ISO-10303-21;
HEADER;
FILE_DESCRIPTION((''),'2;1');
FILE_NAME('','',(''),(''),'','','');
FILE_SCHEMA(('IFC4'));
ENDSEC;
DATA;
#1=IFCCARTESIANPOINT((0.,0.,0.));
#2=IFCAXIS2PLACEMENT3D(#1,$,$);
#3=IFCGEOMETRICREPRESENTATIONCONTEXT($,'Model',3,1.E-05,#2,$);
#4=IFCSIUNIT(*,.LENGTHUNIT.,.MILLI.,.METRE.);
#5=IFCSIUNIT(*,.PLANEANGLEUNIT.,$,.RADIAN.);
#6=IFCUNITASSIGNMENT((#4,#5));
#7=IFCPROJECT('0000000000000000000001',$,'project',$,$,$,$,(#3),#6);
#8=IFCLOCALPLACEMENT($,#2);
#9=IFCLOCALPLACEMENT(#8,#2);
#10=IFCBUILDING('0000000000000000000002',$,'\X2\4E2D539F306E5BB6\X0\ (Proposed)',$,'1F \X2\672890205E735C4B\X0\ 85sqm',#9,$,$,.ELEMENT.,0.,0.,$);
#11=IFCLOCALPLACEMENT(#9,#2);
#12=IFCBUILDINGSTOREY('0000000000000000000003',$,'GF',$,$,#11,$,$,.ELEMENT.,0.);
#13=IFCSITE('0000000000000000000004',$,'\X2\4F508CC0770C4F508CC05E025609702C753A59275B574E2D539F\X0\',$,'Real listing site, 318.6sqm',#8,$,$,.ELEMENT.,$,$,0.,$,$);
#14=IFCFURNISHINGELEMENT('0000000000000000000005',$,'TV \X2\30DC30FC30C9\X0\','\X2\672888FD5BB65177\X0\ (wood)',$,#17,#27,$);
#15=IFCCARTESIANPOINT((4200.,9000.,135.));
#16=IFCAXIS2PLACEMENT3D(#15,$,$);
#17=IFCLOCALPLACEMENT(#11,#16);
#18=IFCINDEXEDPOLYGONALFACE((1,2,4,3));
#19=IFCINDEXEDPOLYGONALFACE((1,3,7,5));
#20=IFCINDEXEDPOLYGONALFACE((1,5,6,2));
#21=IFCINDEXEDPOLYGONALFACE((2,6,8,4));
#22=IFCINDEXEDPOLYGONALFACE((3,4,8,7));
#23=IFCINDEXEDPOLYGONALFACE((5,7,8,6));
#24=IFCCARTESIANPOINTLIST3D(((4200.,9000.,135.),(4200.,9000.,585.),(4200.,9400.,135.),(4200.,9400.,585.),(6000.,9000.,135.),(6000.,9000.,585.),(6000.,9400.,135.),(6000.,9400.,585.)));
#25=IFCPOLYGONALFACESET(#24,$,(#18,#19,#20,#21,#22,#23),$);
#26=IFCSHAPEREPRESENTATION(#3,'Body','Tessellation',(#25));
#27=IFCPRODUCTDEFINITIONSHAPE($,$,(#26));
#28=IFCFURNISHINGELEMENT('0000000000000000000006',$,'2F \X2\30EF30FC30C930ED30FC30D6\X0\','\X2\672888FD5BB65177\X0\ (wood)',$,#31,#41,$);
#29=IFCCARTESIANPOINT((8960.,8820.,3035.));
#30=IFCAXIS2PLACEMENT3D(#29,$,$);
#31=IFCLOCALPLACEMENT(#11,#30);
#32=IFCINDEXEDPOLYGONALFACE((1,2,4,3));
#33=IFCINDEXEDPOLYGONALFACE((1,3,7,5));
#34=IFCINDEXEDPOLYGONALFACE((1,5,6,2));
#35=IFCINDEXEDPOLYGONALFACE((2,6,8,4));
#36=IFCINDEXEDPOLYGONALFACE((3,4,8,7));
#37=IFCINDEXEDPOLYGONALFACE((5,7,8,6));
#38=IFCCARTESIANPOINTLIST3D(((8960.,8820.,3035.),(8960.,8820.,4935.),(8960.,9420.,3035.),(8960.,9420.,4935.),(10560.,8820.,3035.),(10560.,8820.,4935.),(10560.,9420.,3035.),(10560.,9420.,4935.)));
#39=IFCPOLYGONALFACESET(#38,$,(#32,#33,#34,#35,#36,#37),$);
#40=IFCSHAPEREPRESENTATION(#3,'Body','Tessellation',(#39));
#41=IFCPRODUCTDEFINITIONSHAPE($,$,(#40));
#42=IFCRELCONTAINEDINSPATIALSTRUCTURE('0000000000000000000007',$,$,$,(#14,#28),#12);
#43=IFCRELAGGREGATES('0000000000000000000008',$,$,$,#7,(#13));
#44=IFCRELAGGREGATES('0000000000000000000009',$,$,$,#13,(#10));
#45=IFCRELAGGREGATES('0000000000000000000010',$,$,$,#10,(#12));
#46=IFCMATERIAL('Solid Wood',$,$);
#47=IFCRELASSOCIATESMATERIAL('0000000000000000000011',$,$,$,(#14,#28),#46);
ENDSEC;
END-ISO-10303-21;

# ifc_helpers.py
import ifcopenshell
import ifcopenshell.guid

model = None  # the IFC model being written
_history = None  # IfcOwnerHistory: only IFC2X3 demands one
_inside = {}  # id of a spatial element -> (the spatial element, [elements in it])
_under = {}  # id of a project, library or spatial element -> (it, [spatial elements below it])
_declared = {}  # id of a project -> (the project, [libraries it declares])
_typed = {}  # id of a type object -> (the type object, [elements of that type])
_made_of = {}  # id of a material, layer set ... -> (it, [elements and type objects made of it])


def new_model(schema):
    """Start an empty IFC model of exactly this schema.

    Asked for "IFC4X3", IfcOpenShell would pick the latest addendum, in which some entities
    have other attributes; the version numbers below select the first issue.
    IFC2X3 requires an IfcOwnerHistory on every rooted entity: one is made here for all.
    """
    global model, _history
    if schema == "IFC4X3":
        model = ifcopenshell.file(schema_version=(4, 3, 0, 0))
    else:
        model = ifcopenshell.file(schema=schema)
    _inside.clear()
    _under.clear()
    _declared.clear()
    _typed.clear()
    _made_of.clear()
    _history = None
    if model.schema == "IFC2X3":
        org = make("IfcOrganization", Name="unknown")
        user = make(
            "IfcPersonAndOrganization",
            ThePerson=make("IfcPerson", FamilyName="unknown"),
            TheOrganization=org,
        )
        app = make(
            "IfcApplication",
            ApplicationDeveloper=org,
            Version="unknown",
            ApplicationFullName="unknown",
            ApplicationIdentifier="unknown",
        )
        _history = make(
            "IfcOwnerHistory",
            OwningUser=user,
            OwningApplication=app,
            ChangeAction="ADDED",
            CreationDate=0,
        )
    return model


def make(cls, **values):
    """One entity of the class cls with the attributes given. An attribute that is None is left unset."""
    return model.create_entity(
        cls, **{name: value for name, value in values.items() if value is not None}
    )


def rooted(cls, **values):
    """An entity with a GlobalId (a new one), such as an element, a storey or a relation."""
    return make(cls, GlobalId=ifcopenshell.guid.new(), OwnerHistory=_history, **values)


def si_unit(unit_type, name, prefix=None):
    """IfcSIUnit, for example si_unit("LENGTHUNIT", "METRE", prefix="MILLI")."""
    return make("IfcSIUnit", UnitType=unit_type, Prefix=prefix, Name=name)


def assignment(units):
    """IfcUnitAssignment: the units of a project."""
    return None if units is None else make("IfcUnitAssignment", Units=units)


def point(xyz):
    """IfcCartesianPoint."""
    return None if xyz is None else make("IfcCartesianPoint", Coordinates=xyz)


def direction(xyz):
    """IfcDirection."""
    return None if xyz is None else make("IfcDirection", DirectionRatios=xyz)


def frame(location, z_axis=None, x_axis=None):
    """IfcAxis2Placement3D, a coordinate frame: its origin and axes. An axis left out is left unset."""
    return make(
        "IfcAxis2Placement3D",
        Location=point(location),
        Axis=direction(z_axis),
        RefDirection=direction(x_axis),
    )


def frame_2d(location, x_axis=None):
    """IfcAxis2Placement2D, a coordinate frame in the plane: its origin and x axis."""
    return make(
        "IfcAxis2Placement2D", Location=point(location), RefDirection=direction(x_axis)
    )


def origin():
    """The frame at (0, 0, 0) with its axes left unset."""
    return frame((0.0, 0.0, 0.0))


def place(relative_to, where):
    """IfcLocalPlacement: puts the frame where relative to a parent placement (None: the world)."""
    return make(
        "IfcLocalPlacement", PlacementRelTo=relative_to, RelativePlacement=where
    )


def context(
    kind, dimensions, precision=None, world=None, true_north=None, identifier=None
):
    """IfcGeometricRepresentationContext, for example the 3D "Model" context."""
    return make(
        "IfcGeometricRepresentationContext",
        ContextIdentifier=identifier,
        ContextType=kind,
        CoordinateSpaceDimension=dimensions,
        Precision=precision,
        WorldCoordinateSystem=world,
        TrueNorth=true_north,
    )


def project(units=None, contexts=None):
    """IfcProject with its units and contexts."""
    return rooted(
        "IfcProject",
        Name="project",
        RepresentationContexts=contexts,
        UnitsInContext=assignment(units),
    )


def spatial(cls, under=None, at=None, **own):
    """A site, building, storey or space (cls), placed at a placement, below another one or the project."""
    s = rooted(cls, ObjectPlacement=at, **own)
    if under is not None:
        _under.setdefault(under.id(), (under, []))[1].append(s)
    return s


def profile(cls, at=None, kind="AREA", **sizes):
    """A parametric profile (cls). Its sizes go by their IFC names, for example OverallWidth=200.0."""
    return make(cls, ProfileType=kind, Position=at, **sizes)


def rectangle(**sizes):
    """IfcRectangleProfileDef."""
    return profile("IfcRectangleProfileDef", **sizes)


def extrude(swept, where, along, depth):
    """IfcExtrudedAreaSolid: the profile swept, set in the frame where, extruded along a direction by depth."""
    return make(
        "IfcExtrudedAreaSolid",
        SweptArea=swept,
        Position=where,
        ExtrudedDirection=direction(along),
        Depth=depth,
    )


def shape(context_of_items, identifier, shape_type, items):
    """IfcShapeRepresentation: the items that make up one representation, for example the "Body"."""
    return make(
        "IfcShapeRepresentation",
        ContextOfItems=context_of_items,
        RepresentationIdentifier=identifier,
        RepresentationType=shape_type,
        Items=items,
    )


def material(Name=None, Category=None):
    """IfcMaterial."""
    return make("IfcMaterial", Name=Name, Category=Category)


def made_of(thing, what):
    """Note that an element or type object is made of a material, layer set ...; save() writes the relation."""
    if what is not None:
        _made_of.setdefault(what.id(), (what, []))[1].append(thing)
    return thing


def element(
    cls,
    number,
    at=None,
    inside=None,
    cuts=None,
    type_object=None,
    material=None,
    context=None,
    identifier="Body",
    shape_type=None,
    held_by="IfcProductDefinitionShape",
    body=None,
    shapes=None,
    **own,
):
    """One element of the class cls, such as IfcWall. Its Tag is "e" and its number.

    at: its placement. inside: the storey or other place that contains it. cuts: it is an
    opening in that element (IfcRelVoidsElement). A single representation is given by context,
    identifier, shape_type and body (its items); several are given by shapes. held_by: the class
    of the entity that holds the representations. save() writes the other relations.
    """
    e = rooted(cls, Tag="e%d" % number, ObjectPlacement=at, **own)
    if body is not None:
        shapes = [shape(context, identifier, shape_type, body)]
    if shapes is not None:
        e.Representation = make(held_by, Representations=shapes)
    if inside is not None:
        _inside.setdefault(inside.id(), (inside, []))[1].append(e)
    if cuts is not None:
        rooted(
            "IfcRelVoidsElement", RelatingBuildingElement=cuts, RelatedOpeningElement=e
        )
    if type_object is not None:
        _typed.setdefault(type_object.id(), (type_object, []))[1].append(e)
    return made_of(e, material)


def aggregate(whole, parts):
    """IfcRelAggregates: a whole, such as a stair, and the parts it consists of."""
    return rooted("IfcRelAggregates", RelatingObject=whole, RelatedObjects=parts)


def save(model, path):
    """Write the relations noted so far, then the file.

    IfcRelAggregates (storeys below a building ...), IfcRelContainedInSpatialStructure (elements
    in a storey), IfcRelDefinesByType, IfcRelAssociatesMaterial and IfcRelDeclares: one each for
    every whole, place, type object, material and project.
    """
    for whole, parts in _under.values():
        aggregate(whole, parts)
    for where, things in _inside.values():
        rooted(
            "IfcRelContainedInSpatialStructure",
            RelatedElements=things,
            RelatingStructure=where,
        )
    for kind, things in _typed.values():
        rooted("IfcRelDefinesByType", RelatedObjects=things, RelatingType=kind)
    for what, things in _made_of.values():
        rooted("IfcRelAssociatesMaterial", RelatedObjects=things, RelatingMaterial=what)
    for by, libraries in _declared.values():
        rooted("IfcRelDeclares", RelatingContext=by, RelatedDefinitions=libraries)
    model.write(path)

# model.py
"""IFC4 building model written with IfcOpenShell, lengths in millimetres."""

from ifc_helpers import new_model, si_unit, frame, frame_2d, origin, place, context, project, spatial, rectangle, extrude, material, element, save


model = new_model("IFC4")

# Units and contexts
model_context = context("Model", 3, precision=1e-05, world=origin())
ifc_project = project(units=[si_unit("LENGTHUNIT", "METRE", prefix="MILLI"), si_unit("PLANEANGLEUNIT", "RADIAN")], contexts=[model_context])

# Site, building, storey
site_placement = place(None, origin())
site = spatial("IfcSite", under=ifc_project, at=site_placement, Name="佐賀県佐賀市嘉瀬町大字中原", ObjectType="Real listing site, 318.6sqm", CompositionType="ELEMENT", RefElevation=0.0)
building_placement = place(site_placement, origin())
building = spatial("IfcBuilding", under=site, at=building_placement, Name="中原の家 (Proposed)", ObjectType="1F 木造平屋 85sqm", CompositionType="ELEMENT", ElevationOfRefHeight=0.0, ElevationOfTerrain=0.0)
storey_placement = place(building_placement, origin())
storey = spatial("IfcBuildingStorey", under=building, at=storey_placement, Name="GF", CompositionType="ELEMENT", Elevation=0.0)

# Shared definitions
ifc_material_1 = material(Name="Solid Wood")

# Furnishing elements
furnishing_1_placement = place(storey_placement, frame((4200.0, 9000.0, 135.0)))
element("IfcFurnishingElement", 1, at=furnishing_1_placement, inside=storey, material=ifc_material_1, Name="TV ボード", Description="木製家具 (wood)", context=model_context, shape_type="SweptSolid", body=[
    extrude(rectangle(XDim=1800.0, YDim=400.0, at=frame_2d((900.0, 200.0))), frame((4200.0, 9000.0, 135.0)), (0.0, 0.0, 1.0), 450.0),
])
furnishing_2_placement = place(storey_placement, frame((8960.0, 8820.0, 3035.0)))
element("IfcFurnishingElement", 2, at=furnishing_2_placement, inside=storey, material=ifc_material_1, Name="2F ワードローブ", Description="木製家具 (wood)", context=model_context, shape_type="SweptSolid", body=[
    extrude(rectangle(XDim=1600.0, YDim=600.0, at=frame_2d((800.0, 300.0))), frame((8960.0, 8820.0, 3035.0)), (0.0, 0.0, 1.0), 1900.0),
])

save(model, "model.ifc")
